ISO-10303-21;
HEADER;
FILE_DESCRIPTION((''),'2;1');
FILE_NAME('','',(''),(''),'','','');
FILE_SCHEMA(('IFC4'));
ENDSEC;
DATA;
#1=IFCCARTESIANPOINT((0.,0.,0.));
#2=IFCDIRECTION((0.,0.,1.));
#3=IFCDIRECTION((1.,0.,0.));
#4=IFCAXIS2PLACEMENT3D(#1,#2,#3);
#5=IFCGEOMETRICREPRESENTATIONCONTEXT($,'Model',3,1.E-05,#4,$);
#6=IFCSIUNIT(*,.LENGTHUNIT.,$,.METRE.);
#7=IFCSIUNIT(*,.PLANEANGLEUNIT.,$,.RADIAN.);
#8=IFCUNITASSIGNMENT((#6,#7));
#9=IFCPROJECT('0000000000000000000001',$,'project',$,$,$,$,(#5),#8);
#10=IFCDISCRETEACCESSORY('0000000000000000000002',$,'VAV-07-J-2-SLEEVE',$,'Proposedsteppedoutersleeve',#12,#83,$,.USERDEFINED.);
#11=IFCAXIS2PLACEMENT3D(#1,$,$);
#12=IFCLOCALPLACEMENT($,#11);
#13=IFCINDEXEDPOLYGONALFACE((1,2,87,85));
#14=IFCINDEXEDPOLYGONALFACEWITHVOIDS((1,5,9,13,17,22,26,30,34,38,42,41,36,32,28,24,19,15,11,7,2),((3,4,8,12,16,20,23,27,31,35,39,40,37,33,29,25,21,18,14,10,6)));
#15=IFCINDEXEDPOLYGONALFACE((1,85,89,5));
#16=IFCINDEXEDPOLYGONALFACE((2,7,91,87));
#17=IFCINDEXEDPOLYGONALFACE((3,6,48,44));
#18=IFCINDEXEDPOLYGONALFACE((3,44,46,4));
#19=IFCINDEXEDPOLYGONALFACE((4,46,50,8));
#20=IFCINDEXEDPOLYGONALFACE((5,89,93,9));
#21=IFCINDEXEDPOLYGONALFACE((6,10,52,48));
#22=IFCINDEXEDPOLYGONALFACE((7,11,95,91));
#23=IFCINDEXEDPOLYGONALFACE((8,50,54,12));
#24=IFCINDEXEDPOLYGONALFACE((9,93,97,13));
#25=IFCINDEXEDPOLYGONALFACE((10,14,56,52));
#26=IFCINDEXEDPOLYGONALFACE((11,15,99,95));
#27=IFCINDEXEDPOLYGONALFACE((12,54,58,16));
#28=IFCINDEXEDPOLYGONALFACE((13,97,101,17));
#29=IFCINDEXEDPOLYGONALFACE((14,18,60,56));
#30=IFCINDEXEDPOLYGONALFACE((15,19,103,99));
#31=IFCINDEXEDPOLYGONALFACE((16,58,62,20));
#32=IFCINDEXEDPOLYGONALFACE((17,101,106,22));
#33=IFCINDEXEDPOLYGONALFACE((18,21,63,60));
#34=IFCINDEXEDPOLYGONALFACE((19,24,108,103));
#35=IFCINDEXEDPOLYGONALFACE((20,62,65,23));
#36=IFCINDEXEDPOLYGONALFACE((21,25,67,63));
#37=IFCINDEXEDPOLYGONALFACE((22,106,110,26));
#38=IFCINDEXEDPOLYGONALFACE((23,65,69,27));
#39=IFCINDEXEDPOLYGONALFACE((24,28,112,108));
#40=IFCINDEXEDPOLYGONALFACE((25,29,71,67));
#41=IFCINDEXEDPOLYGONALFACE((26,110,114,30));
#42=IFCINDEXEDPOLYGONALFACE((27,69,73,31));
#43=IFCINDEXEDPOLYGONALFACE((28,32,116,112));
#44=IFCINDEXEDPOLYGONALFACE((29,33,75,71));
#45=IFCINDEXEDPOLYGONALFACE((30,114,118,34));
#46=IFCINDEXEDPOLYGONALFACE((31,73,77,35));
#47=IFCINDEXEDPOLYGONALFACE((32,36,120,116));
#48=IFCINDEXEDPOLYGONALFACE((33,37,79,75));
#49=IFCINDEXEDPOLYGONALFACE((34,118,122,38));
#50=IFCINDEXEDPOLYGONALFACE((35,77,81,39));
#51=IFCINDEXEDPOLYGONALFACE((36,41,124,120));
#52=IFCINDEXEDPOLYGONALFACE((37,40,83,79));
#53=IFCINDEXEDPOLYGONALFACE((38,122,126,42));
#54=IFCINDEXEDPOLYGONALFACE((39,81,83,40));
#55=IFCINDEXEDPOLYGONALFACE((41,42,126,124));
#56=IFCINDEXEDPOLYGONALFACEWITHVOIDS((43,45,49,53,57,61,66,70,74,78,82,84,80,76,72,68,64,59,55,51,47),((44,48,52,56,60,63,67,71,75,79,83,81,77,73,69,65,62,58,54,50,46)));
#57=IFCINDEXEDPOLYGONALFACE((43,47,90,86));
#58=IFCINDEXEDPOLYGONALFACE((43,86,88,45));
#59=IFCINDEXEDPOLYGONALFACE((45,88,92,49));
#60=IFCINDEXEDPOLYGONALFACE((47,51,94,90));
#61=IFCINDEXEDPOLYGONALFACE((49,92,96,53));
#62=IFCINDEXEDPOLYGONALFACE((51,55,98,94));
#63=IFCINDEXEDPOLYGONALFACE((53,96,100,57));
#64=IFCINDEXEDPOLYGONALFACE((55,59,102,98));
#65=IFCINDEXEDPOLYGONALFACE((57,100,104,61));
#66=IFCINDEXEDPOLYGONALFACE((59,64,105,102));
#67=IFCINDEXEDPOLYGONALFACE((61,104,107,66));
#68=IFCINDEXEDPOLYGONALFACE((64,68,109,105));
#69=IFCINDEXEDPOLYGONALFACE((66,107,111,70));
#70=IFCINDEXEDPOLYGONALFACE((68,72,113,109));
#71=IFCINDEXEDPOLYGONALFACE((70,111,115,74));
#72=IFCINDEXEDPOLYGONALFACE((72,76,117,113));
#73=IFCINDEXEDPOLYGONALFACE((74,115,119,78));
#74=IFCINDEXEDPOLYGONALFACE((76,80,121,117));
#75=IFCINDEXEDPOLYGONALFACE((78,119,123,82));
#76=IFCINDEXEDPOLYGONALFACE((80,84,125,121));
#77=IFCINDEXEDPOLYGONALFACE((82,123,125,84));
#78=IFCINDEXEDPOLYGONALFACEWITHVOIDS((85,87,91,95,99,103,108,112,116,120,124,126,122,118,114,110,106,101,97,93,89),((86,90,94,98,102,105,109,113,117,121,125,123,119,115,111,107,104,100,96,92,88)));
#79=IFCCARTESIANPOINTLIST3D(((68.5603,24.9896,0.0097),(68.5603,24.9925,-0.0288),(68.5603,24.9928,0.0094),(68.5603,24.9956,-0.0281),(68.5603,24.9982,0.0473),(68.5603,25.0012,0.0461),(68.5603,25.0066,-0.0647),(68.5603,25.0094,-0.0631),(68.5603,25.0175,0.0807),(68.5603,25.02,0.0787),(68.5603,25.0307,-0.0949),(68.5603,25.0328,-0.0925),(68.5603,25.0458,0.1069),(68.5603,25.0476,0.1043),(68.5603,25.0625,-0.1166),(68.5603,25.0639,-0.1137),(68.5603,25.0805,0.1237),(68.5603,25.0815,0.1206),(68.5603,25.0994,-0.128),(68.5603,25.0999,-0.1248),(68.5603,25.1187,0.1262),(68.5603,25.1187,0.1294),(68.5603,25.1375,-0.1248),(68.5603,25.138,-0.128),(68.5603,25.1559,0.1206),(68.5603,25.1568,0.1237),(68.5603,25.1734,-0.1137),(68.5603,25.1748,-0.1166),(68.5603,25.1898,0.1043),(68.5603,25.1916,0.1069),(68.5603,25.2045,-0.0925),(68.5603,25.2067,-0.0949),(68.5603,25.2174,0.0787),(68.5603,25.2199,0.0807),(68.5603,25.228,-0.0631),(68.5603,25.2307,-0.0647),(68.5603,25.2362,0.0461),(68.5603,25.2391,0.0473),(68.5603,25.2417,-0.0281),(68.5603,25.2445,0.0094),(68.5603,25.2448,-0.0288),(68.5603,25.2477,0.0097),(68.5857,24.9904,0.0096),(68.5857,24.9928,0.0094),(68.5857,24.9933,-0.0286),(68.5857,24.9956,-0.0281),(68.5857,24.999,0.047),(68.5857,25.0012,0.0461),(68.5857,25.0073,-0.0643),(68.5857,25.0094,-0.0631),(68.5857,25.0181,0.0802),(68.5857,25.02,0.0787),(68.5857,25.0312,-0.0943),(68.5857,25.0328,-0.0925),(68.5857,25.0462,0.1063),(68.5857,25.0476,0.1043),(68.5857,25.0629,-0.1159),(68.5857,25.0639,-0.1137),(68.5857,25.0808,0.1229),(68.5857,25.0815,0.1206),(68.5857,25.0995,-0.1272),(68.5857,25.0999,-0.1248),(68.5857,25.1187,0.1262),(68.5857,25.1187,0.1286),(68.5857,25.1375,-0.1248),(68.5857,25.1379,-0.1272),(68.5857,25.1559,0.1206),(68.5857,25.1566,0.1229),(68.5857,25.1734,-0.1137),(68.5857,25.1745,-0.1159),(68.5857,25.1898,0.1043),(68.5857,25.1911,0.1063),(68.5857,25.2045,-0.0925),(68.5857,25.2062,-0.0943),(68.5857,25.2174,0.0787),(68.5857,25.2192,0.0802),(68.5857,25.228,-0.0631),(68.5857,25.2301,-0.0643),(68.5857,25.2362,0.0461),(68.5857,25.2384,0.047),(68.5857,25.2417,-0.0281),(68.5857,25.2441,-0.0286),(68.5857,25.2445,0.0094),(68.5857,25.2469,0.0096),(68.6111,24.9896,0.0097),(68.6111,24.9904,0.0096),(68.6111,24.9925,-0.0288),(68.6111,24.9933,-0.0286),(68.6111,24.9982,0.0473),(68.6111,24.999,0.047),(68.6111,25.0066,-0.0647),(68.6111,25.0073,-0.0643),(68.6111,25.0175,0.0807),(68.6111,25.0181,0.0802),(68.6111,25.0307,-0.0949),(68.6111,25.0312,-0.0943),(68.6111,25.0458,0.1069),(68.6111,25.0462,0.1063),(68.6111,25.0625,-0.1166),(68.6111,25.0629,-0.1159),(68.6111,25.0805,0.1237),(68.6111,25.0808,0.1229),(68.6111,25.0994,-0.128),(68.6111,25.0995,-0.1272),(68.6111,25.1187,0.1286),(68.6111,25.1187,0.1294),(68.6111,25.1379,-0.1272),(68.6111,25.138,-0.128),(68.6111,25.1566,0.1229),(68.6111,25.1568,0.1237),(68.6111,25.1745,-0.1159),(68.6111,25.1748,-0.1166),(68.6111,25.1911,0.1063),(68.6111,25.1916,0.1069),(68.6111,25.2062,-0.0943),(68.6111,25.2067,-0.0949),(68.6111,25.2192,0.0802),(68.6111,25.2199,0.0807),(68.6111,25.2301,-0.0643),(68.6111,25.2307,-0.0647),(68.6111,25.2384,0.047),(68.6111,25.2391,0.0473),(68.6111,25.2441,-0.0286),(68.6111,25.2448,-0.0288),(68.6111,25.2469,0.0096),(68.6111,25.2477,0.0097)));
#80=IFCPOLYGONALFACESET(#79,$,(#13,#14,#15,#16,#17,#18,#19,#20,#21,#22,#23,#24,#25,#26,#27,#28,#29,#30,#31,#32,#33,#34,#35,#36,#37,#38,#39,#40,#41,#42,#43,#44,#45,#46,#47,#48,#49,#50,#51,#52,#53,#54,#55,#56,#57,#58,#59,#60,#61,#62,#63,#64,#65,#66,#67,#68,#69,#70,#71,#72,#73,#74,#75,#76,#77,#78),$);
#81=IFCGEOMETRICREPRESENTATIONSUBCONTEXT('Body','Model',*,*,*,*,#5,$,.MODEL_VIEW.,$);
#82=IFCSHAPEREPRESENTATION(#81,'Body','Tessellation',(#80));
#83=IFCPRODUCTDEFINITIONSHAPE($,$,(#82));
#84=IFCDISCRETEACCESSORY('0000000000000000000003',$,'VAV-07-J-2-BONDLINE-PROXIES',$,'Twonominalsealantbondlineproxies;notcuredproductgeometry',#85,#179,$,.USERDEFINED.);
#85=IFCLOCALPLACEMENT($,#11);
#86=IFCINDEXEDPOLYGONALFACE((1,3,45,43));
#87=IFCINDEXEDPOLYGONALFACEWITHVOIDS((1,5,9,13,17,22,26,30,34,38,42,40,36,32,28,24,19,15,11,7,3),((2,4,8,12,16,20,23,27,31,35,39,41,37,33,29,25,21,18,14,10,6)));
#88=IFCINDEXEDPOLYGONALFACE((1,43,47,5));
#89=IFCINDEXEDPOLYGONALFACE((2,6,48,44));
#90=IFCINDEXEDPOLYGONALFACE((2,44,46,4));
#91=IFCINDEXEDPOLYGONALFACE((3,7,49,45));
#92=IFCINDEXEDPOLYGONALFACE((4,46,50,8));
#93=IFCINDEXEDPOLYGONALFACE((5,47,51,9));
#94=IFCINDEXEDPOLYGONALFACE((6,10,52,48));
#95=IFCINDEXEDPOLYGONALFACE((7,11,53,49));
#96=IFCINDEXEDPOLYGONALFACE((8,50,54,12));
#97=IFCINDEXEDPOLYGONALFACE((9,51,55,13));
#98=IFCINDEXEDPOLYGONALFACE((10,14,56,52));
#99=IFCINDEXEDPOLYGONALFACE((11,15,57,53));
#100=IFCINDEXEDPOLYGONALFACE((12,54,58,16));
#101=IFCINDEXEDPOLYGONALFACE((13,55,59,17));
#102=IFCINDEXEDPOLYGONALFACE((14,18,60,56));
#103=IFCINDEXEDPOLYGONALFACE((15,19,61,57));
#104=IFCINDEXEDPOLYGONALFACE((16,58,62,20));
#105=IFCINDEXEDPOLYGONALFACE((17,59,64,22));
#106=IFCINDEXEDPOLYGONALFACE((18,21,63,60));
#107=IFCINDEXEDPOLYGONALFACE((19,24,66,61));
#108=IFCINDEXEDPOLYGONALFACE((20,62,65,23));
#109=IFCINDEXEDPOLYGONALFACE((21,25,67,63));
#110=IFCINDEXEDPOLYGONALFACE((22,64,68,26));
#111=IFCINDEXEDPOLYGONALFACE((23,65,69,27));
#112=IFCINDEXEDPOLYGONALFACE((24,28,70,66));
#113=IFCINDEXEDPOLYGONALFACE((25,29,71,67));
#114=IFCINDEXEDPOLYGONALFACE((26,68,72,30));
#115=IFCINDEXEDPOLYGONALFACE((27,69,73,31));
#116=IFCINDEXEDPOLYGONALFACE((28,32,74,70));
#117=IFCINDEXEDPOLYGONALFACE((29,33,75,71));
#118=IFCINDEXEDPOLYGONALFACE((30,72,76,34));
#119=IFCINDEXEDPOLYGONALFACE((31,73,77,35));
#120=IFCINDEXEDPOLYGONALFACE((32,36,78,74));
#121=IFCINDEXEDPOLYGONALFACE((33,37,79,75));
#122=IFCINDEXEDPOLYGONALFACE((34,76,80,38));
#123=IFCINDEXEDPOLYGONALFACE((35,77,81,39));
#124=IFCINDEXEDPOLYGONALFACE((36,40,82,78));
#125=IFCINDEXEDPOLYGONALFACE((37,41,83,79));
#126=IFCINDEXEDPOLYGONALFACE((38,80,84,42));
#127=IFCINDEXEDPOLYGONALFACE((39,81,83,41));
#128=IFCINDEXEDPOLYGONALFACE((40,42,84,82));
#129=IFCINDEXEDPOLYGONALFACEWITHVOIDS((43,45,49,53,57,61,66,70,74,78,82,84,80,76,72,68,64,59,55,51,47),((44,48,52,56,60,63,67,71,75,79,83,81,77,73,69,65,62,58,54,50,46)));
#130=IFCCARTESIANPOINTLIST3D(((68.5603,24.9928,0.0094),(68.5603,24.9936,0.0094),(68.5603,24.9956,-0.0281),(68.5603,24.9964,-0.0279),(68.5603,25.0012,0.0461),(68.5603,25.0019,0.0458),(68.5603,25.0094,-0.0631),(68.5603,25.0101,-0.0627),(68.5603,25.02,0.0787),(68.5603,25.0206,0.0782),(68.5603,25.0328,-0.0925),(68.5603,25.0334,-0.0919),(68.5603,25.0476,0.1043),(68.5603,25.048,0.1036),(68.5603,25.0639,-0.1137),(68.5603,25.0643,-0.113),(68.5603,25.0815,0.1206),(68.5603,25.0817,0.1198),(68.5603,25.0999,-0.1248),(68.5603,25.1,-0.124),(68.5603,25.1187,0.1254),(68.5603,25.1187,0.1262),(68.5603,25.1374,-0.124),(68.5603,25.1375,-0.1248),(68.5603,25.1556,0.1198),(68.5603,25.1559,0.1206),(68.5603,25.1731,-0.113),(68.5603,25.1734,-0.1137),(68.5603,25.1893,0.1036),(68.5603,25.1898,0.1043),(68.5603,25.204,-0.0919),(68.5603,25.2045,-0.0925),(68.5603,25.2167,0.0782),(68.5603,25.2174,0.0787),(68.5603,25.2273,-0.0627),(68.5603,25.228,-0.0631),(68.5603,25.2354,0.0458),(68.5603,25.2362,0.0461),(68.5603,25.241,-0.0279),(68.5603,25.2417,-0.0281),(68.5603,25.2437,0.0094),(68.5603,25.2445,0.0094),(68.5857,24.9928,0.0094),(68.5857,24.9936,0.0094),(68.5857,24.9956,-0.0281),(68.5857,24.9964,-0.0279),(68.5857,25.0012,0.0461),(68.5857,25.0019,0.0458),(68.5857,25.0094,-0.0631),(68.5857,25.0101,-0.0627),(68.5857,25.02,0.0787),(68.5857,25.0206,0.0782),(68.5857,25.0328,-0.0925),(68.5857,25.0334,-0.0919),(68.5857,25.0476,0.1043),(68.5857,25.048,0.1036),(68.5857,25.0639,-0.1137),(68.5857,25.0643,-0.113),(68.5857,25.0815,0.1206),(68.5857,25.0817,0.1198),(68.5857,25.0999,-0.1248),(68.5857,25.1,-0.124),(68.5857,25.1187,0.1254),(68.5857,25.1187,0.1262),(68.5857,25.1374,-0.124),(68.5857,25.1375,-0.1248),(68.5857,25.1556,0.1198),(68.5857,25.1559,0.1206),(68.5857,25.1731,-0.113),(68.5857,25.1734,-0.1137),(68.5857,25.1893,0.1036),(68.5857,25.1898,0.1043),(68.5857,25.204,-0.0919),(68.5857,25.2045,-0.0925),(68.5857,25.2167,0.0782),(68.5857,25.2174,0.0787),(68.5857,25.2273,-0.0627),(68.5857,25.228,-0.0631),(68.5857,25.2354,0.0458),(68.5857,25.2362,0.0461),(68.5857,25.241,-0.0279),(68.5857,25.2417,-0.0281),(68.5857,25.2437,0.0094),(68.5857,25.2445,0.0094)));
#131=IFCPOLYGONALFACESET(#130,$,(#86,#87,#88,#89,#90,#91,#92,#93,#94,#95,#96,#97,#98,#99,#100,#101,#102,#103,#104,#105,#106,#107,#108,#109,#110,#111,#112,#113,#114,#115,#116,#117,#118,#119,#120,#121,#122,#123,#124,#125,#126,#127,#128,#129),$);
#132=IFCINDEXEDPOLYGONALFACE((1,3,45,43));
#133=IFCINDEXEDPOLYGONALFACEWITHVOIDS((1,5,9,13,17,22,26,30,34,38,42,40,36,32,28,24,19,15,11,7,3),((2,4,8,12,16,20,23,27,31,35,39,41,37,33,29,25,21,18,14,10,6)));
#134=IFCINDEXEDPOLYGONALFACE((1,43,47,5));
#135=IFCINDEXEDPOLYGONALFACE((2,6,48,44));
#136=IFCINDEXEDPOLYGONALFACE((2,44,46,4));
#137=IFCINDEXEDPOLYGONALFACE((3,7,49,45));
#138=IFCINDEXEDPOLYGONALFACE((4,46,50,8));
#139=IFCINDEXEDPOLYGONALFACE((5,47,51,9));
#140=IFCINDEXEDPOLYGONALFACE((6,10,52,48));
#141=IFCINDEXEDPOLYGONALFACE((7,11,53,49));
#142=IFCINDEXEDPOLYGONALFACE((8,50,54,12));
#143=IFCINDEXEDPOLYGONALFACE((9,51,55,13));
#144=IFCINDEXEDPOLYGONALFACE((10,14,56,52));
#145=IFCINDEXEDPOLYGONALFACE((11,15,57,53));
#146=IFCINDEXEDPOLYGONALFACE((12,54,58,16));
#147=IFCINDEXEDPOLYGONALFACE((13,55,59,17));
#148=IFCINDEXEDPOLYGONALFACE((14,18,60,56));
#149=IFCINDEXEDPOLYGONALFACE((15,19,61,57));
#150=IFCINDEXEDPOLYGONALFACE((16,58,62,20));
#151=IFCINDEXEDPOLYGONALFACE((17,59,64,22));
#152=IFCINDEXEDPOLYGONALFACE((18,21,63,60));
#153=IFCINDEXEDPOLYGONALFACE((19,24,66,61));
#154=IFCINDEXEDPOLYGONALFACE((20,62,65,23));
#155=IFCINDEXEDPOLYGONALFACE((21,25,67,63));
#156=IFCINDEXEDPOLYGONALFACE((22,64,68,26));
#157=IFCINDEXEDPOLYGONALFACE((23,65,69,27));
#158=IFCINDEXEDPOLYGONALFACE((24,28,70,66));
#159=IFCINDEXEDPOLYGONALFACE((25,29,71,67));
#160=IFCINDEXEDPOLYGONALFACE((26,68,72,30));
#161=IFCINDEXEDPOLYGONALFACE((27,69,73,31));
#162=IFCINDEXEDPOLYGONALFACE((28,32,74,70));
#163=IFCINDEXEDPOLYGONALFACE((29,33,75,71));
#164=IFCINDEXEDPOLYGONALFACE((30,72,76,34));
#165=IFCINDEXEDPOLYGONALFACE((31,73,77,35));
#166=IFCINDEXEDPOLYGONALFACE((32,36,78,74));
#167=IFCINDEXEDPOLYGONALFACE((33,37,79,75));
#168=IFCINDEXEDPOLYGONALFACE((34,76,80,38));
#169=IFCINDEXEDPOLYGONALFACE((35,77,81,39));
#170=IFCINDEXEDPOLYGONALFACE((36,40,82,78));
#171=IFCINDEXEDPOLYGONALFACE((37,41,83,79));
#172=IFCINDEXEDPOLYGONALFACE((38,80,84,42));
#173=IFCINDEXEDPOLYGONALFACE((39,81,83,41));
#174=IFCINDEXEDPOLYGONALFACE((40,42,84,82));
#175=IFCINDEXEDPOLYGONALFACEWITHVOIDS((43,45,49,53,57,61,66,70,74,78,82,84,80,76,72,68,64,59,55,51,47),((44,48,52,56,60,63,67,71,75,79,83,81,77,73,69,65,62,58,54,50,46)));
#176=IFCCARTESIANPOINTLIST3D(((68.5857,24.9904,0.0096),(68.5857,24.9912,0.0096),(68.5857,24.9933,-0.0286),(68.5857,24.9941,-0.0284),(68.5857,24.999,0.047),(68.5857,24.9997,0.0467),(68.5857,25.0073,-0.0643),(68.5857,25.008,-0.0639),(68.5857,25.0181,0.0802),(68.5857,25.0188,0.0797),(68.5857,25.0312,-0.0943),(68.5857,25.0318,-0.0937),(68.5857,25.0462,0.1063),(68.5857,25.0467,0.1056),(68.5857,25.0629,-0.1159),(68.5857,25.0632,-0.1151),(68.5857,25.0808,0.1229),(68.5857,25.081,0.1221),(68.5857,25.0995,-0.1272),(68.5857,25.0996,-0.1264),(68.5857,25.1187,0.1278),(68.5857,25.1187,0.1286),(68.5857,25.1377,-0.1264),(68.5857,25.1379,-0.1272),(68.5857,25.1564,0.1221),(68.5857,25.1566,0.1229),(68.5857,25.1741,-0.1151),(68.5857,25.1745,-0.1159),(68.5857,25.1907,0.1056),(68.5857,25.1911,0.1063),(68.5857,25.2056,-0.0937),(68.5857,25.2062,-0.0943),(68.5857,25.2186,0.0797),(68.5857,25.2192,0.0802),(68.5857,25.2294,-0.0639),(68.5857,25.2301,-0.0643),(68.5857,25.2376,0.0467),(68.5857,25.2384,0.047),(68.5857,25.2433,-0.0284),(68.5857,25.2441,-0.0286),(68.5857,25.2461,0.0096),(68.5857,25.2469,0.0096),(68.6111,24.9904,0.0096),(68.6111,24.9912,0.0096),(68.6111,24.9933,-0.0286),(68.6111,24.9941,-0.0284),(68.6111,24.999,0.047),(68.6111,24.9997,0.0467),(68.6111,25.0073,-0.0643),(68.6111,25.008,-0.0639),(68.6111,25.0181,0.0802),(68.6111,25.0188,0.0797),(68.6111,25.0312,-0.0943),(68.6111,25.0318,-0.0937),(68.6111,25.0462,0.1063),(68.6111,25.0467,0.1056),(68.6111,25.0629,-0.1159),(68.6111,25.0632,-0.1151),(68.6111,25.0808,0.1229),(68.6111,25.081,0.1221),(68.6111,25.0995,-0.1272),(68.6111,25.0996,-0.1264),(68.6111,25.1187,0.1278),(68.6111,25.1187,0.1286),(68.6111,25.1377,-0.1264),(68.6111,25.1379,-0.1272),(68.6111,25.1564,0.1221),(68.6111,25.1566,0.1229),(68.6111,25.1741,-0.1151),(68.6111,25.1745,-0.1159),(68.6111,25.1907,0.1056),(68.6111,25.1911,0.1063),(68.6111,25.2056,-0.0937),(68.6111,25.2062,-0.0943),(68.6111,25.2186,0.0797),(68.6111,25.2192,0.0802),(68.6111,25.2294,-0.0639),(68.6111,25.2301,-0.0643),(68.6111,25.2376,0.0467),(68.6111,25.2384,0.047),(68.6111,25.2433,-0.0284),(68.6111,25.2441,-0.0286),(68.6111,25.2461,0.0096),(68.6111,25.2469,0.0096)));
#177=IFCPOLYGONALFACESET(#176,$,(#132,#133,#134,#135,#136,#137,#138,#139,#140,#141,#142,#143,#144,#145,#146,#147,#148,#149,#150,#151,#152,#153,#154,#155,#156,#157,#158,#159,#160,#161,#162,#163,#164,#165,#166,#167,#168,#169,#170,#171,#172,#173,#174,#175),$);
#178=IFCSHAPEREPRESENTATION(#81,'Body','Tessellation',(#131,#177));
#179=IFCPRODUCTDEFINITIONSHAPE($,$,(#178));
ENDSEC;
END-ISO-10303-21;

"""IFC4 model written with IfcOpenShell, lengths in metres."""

from ifc_helpers import new_model, entity, si_unit, frame, origin_with_axes, place, context, subcontext, project, element, save


model = new_model("IFC4")

# Units and contexts
model_context = context("Model", 3, precision=1e-05, world=origin_with_axes())
body_context = subcontext(model_context, "Body", "Model", "MODEL_VIEW")
ifc_project = project(units=[si_unit("LENGTHUNIT", "METRE"), si_unit("PLANEANGLEUNIT", "RADIAN")], contexts=[model_context])

# Discrete accessories
discrete_accessory_1_placement = place(None, frame((68.5857, 25.1187, 0.0), z_axis=(0.0, 1.0, 0.0), x_axis=(0.0, 0.0, 1.0)))
element("IfcDiscreteAccessory", 1, at=discrete_accessory_1_placement, Name="VAV-07-J-2-SLEEVE", ObjectType="Proposedsteppedoutersleeve", PredefinedType="USERDEFINED", context=body_context, shape_type="SweptSolid", body=[
    entity("IfcRevolvedAreaSolid", entity("IfcArbitraryClosedProfileDef", "AREA", None, entity("IfcPolyline", [entity("IfcCartesianPoint", [0.1262, -0.0254]), entity("IfcCartesianPoint", [0.1294, -0.0254]), entity("IfcCartesianPoint", [0.1294, 0.0254]), entity("IfcCartesianPoint", [0.1286, 0.0254]), entity("IfcCartesianPoint", [0.1286, 0.0]), entity("IfcCartesianPoint", [0.1262, 0.0]), entity("IfcCartesianPoint", [0.1262, -0.0254])])), entity("IfcAxis2Placement3D", entity("IfcCartesianPoint", [0.0, 0.0, 0.0])), entity("IfcAxis1Placement", entity("IfcCartesianPoint", [0.0, 0.0, 0.0]), entity("IfcDirection", [0.0, 1.0, 0.0])), 6.283185),
])
discrete_accessory_2_placement = place(None, frame((68.5857, 25.1187, 0.0), z_axis=(0.0, 1.0, 0.0), x_axis=(0.0, 0.0, 1.0)))
element("IfcDiscreteAccessory", 2, at=discrete_accessory_2_placement, Name="VAV-07-J-2-BONDLINE-PROXIES", ObjectType="Twonominalsealantbondlineproxies;notcuredproductgeometry", PredefinedType="USERDEFINED", context=body_context, shape_type="SweptSolid", body=[
    entity("IfcRevolvedAreaSolid", entity("IfcArbitraryClosedProfileDef", "AREA", None, entity("IfcPolyline", [entity("IfcCartesianPoint", [0.1254, -0.0254]), entity("IfcCartesianPoint", [0.1262, -0.0254]), entity("IfcCartesianPoint", [0.1262, 0.0]), entity("IfcCartesianPoint", [0.1254, 0.0]), entity("IfcCartesianPoint", [0.1254, -0.0254])])), entity("IfcAxis2Placement3D", entity("IfcCartesianPoint", [0.0, 0.0, 0.0])), entity("IfcAxis1Placement", entity("IfcCartesianPoint", [0.0, 0.0, 0.0]), entity("IfcDirection", [0.0, 1.0, 0.0])), 6.283185),
    entity("IfcRevolvedAreaSolid", entity("IfcArbitraryClosedProfileDef", "AREA", None, entity("IfcPolyline", [entity("IfcCartesianPoint", [0.1278, 0.0]), entity("IfcCartesianPoint", [0.1286, 0.0]), entity("IfcCartesianPoint", [0.1286, 0.0254]), entity("IfcCartesianPoint", [0.1278, 0.0254]), entity("IfcCartesianPoint", [0.1278, 0.0])])), entity("IfcAxis2Placement3D", entity("IfcCartesianPoint", [0.0, 0.0, 0.0])), entity("IfcAxis1Placement", entity("IfcCartesianPoint", [0.0, 0.0, 0.0]), entity("IfcDirection", [0.0, 1.0, 0.0])), 6.283185),
])

save(model, "model.ifc")
